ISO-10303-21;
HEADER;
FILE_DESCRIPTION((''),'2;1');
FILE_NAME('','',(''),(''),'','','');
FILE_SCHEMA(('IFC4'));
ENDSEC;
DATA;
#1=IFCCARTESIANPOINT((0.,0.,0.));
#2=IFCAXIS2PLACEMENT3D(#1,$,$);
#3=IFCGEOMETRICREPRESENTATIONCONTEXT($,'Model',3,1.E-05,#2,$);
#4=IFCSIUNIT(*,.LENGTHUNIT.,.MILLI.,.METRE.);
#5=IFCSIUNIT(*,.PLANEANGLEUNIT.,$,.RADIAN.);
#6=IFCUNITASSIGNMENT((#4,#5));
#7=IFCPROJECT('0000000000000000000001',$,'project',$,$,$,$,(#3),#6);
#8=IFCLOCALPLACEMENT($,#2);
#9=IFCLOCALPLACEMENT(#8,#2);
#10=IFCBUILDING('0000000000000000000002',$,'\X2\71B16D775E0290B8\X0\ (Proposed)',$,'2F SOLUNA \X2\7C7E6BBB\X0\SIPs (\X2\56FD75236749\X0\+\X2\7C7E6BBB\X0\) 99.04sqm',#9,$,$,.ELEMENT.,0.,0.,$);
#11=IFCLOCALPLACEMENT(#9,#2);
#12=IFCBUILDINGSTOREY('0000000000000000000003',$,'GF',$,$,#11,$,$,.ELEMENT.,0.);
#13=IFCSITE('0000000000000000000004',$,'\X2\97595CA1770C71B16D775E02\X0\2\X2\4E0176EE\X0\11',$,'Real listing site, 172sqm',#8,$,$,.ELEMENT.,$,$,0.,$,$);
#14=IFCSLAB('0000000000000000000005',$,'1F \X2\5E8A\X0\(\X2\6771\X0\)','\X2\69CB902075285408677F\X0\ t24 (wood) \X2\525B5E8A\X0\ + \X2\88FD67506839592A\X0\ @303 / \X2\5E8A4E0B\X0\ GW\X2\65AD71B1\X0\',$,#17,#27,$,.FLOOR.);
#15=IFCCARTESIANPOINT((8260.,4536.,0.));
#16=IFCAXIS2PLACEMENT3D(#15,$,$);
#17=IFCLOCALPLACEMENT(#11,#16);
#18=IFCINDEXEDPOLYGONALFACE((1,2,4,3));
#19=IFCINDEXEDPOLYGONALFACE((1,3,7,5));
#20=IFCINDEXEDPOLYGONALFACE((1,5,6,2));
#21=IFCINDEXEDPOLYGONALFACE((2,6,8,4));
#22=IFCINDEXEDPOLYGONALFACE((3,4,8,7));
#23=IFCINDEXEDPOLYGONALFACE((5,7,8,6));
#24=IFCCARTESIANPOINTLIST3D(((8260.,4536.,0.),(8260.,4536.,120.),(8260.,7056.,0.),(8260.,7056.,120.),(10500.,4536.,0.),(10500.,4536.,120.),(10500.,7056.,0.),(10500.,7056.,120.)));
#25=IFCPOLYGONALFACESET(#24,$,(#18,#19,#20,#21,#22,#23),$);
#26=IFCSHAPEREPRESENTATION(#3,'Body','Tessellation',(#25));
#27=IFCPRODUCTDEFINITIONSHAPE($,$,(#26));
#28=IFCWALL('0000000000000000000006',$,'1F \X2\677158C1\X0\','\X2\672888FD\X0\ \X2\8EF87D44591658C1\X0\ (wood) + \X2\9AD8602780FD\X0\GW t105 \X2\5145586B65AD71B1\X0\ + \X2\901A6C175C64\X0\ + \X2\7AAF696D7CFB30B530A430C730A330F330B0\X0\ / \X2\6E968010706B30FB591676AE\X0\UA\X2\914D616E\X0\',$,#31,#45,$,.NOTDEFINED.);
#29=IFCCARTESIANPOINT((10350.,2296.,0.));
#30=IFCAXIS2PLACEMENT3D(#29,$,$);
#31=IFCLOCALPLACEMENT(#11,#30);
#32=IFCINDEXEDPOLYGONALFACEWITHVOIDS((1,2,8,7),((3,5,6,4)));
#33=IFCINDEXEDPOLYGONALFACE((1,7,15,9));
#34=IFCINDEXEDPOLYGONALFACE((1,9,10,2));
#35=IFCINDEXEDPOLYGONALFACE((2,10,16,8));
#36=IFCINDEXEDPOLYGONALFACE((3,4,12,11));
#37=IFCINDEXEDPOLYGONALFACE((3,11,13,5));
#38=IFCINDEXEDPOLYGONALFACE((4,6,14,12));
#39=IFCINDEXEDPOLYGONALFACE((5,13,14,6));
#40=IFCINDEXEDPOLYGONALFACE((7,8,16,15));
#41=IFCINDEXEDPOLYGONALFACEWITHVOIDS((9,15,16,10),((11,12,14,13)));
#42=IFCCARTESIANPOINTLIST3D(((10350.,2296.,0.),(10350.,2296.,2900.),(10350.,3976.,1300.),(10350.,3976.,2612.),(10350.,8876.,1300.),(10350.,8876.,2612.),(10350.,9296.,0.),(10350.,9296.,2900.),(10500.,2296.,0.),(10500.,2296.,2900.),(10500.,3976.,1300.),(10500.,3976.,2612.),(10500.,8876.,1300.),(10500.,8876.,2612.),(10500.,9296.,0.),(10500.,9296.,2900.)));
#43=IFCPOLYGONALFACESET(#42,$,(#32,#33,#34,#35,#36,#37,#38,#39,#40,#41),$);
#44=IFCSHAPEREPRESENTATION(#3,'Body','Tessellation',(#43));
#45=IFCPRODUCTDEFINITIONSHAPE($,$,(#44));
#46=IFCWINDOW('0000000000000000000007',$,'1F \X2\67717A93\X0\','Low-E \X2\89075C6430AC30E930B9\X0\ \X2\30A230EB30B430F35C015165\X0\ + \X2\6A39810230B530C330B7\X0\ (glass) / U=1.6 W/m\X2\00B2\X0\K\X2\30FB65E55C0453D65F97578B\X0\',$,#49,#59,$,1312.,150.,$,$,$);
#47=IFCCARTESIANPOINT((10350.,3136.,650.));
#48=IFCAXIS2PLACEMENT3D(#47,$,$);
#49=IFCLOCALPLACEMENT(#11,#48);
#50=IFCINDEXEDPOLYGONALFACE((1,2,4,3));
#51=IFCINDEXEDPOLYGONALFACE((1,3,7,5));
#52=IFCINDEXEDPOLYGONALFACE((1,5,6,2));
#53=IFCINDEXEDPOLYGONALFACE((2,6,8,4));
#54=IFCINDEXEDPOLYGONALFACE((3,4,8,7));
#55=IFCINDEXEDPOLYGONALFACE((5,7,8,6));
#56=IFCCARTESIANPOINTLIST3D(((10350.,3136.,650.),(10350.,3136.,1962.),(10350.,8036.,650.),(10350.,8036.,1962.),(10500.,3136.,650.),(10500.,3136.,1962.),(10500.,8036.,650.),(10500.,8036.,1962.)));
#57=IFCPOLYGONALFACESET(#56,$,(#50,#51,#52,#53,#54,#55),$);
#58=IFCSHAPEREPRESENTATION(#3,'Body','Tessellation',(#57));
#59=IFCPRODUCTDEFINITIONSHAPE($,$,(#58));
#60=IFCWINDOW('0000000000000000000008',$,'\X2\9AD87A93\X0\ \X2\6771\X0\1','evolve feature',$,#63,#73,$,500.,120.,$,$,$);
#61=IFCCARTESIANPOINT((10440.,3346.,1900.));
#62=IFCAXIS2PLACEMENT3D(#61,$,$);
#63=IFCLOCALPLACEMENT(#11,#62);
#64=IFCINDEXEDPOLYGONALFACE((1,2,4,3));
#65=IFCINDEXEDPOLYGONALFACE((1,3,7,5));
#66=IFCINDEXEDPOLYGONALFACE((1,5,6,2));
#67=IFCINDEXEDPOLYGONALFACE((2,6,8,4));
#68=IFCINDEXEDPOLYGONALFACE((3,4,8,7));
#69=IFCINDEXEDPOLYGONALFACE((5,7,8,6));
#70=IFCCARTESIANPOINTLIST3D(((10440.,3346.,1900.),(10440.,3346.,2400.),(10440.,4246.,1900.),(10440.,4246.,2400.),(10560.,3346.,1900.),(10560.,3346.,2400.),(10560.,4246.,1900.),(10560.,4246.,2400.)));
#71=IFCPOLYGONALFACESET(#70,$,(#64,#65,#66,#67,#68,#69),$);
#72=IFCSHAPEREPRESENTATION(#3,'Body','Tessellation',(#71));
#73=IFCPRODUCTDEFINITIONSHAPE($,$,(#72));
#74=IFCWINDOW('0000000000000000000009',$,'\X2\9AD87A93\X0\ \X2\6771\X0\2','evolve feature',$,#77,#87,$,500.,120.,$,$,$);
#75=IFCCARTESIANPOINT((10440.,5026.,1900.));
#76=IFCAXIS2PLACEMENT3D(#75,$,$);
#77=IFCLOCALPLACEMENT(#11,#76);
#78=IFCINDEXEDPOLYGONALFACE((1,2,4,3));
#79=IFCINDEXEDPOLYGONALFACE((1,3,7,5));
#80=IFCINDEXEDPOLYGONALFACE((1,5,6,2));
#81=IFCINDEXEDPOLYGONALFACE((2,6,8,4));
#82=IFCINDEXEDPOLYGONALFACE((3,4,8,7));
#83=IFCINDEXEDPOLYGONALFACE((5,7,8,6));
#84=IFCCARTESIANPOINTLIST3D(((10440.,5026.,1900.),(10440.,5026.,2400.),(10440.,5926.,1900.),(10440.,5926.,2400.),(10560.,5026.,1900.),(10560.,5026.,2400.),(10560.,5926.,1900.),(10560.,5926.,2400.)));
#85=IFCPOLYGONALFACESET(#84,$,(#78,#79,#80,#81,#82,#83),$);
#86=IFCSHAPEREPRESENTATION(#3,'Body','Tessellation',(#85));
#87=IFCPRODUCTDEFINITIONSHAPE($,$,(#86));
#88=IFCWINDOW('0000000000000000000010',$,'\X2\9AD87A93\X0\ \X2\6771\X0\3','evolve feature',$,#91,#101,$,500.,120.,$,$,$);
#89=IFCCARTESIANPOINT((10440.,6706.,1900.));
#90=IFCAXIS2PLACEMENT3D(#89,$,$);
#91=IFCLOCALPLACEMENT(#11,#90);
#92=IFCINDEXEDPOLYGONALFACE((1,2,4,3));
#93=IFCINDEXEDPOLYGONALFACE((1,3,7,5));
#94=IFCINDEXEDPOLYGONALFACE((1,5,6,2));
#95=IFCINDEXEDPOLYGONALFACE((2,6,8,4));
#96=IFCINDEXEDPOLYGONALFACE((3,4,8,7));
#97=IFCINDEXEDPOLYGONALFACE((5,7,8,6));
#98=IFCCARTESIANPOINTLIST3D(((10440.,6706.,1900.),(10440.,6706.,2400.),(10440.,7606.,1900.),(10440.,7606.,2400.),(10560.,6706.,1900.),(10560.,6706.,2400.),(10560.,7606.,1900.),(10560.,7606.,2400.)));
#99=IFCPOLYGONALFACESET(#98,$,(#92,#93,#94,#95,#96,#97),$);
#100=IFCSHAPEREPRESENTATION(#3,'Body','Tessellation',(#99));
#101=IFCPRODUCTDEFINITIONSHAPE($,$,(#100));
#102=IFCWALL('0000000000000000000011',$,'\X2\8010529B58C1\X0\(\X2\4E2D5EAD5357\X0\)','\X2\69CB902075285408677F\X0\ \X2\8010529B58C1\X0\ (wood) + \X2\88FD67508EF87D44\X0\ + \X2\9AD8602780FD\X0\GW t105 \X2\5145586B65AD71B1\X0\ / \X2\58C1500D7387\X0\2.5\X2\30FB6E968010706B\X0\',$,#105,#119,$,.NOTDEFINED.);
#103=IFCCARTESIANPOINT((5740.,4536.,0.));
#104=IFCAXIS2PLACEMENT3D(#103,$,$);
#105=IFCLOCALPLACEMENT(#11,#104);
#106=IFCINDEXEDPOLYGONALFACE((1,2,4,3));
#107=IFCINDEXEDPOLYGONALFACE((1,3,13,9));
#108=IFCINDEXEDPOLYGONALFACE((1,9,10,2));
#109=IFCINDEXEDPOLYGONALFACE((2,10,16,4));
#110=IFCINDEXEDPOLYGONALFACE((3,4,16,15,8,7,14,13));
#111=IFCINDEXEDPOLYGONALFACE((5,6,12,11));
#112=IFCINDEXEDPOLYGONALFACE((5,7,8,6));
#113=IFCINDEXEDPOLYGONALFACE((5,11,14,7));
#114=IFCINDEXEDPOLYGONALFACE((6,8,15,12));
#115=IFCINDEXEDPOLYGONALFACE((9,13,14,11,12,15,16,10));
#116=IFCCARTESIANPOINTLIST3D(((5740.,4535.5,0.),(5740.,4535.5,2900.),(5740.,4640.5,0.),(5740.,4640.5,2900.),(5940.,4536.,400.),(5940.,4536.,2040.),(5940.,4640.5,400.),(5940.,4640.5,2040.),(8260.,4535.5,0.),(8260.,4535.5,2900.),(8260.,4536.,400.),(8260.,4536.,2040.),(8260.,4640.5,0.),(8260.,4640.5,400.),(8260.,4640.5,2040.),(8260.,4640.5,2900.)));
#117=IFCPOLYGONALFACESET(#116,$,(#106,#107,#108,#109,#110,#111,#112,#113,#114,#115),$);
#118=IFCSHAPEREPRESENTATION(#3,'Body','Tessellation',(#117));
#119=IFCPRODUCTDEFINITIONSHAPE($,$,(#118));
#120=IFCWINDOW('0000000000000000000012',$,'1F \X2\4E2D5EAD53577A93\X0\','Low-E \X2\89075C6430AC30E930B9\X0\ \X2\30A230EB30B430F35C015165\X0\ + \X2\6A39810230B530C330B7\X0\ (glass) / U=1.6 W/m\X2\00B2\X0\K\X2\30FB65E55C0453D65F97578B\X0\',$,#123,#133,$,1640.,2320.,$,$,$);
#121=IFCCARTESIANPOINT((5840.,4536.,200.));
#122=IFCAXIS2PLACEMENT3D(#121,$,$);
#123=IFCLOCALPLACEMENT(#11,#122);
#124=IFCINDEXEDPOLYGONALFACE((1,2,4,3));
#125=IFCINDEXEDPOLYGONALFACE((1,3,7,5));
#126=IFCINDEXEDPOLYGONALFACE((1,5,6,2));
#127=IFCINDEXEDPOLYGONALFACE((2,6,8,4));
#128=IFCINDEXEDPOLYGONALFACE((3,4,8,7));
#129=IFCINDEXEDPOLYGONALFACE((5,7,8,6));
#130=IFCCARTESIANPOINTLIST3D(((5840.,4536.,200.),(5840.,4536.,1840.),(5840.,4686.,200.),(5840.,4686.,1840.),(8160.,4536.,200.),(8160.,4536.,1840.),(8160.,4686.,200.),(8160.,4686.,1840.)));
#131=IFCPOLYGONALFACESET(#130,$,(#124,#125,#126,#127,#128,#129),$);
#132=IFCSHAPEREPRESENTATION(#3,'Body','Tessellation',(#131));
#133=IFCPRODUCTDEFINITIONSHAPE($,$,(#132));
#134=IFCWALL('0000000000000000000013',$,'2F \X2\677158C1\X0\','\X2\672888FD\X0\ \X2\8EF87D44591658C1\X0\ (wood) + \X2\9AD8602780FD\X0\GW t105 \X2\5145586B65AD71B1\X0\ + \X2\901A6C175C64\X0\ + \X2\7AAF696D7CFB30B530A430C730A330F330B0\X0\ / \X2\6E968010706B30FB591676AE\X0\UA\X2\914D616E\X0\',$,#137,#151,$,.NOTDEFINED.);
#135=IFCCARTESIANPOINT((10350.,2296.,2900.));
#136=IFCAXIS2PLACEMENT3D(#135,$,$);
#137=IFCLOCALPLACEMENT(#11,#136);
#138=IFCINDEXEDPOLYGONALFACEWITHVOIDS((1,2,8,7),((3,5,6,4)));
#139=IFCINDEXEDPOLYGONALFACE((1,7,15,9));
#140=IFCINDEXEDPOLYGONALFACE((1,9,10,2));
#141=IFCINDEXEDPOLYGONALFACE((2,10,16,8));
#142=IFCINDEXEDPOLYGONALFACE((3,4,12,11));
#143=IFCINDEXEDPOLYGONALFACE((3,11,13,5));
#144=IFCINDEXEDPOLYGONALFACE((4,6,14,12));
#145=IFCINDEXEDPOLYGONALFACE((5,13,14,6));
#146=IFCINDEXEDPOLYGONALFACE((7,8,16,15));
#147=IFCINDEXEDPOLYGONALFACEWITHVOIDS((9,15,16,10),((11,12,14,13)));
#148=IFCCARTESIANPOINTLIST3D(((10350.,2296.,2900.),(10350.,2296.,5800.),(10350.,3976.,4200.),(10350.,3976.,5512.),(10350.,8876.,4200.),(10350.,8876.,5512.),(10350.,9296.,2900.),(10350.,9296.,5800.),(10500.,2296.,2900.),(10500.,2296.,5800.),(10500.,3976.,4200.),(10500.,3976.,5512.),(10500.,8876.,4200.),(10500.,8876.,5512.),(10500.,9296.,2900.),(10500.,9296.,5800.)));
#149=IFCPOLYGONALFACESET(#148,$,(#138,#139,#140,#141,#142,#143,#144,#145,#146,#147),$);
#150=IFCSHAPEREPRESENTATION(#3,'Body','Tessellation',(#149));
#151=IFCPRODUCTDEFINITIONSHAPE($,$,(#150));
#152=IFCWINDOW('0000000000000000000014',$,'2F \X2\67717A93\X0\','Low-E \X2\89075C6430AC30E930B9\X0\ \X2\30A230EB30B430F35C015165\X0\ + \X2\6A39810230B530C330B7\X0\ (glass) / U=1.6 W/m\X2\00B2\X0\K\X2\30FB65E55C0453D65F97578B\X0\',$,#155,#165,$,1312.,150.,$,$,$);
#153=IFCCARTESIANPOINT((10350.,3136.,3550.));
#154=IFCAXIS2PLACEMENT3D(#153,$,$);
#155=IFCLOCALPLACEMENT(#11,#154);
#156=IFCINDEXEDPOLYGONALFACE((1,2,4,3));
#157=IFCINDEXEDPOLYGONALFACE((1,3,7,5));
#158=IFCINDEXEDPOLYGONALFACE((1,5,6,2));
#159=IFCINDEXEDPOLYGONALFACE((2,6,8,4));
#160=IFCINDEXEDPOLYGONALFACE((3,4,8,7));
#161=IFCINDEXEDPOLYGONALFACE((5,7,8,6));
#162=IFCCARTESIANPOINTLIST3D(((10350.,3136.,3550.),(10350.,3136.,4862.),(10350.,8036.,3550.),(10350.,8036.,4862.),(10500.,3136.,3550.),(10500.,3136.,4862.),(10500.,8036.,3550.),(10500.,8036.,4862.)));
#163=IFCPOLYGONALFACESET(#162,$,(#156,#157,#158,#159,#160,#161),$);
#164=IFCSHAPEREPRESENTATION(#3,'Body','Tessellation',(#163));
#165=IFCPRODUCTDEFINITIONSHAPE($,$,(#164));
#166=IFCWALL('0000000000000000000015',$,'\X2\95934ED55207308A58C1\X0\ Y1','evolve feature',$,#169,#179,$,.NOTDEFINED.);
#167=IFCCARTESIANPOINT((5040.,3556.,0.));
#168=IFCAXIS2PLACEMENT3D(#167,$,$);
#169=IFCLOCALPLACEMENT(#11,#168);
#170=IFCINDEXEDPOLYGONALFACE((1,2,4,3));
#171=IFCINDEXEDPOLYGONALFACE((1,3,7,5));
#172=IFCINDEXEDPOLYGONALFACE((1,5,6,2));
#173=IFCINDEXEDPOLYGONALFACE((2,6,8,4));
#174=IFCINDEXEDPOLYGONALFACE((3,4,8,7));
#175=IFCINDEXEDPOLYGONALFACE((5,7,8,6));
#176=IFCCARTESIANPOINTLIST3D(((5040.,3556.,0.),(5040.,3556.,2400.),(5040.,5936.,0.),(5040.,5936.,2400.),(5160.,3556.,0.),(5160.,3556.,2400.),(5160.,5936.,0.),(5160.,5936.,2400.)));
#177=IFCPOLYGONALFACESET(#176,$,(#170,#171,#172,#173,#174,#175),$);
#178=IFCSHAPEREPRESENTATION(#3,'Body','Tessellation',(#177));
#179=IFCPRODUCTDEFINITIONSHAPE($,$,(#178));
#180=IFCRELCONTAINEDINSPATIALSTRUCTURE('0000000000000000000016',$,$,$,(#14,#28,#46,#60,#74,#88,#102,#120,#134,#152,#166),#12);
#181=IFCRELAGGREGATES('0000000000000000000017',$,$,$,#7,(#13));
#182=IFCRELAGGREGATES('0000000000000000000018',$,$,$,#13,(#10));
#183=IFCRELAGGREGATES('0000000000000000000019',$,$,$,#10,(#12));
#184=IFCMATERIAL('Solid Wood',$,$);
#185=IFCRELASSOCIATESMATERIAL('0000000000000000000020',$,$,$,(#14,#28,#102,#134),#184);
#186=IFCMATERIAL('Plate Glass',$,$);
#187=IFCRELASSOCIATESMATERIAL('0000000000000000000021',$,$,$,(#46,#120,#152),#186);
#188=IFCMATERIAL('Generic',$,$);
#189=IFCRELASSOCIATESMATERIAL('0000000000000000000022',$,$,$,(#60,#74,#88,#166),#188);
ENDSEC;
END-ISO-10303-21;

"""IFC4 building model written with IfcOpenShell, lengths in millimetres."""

from ifc_helpers import new_model, si_unit, frame, frame_2d, origin, place, context, project, spatial, rectangle, extrude, material, element, fill, save


model = new_model("IFC4")

# Units and contexts
model_context = context("Model", 3, precision=1e-05, world=origin())
ifc_project = project(units=[si_unit("LENGTHUNIT", "METRE", prefix="MILLI"), si_unit("PLANEANGLEUNIT", "RADIAN")], contexts=[model_context])

# Site, building, storey
site_placement = place(None, origin())
site = spatial("IfcSite", under=ifc_project, at=site_placement, Name="静岡県熱海市2丁目11", ObjectType="Real listing site, 172sqm", CompositionType="ELEMENT", RefElevation=0.0)
building_placement = place(site_placement, origin())
building = spatial("IfcBuilding", under=site, at=building_placement, Name="熱海市邸 (Proposed)", ObjectType="2F SOLUNA 籾殻SIPs (国産杉+籾殻) 99.04sqm", CompositionType="ELEMENT", ElevationOfRefHeight=0.0, ElevationOfTerrain=0.0)
storey_placement = place(building_placement, origin())
storey = spatial("IfcBuildingStorey", under=building, at=storey_placement, Name="GF", CompositionType="ELEMENT", Elevation=0.0)

# Slab
ifc_material_1 = material(Name="Solid Wood")
slab_placement = place(storey_placement, frame((8260.0, 4536.0, 0.0)))
element("IfcSlab", 1, at=slab_placement, inside=storey, material=ifc_material_1, Name="1F 床(東)", Description="構造用合板 t24 (wood) 剛床 + 製材根太 @303 / 床下 GW断熱", PredefinedType="FLOOR", context=model_context, shape_type="SweptSolid", body=[
    extrude(rectangle(XDim=2240.0, YDim=2520.0, at=frame_2d((1120.0, 1260.0))), frame((8260.0, 4536.0, 0.0)), (0.0, 0.0, 1.0), 120.0),
])

# Wall, openings, windows
wall_1_placement = place(storey_placement, frame((10350.0, 2296.0, 0.0)))
wall_1 = element("IfcWall", 2, at=wall_1_placement, inside=storey, material=ifc_material_1, Name="1F 東壁", Description="木製 軸組外壁 (wood) + 高性能GW t105 充填断熱 + 通気層 + 窯業系サイディング / 準耐火・外皮UA配慮", PredefinedType="NOTDEFINED", context=model_context, shape_type="SweptSolid", body=[
    extrude(rectangle(XDim=150.0, YDim=7000.0, at=frame_2d((75.0, 3500.0))), frame((10350.0, 2296.0, 0.0)), (0.0, 0.0, 1.0), 2900.0),
])
opening_1_placement = place(storey_placement, frame((10350.0, 3136.0, 650.0)))
opening_1 = element("IfcOpeningElement", 3, at=opening_1_placement, cuts=wall_1, PredefinedType="NOTDEFINED", context=model_context, shape_type="SweptSolid", body=[
    extrude(rectangle(XDim=150.0, YDim=4900.0, at=frame_2d((75.0, 2450.0))), frame((10350.0, 3136.0, 650.0)), (0.0, 0.0, 1.0), 1312.0),
])
opening_2_placement = place(storey_placement, frame((10440.0, 3346.0, 1900.0)))
opening_2 = element("IfcOpeningElement", 4, at=opening_2_placement, cuts=wall_1, PredefinedType="NOTDEFINED", context=model_context, shape_type="SweptSolid", body=[
    extrude(rectangle(XDim=120.0, YDim=900.0, at=frame_2d((60.0, 450.0))), frame((10440.0, 3346.0, 1900.0)), (0.0, 0.0, 1.0), 500.0),
])
opening_3_placement = place(storey_placement, frame((10440.0, 5026.0, 1900.0)))
opening_3 = element("IfcOpeningElement", 5, at=opening_3_placement, cuts=wall_1, PredefinedType="NOTDEFINED", context=model_context, shape_type="SweptSolid", body=[
    extrude(rectangle(XDim=120.0, YDim=900.0, at=frame_2d((60.0, 450.0))), frame((10440.0, 5026.0, 1900.0)), (0.0, 0.0, 1.0), 500.0),
])
opening_4_placement = place(storey_placement, frame((10440.0, 6706.0, 1900.0)))
opening_4 = element("IfcOpeningElement", 6, at=opening_4_placement, cuts=wall_1, PredefinedType="NOTDEFINED", context=model_context, shape_type="SweptSolid", body=[
    extrude(rectangle(XDim=120.0, YDim=900.0, at=frame_2d((60.0, 450.0))), frame((10440.0, 6706.0, 1900.0)), (0.0, 0.0, 1.0), 500.0),
])
ifc_material_2 = material(Name="Plate Glass")
window_1_placement = place(storey_placement, frame((10350.0, 3136.0, 650.0)))
window_1 = element("IfcWindow", 7, at=window_1_placement, inside=storey, material=ifc_material_2, Name="1F 東窓", Description="Low-E 複層ガラス アルゴン封入 + 樹脂サッシ (glass) / U=1.6 W/m²K・日射取得型", OverallHeight=1312.0, OverallWidth=150.0, context=model_context, shape_type="SweptSolid", body=[
    extrude(rectangle(XDim=150.0, YDim=4900.0, at=frame_2d((75.0, 2450.0))), frame((10350.0, 3136.0, 650.0)), (0.0, 0.0, 1.0), 1312.0),
])
fill(opening_1, window_1)
ifc_material_3 = material(Name="Generic")
window_2_placement = place(storey_placement, frame((10440.0, 3346.0, 1900.0)))
window_2 = element("IfcWindow", 8, at=window_2_placement, inside=storey, material=ifc_material_3, Name="高窓 東1", Description="evolve feature", OverallHeight=500.0, OverallWidth=120.0, context=model_context, shape_type="SweptSolid", body=[
    extrude(rectangle(XDim=120.0, YDim=900.0, at=frame_2d((60.0, 450.0))), frame((10440.0, 3346.0, 1900.0)), (0.0, 0.0, 1.0), 500.0),
])
fill(opening_2, window_2)
window_3_placement = place(storey_placement, frame((10440.0, 5026.0, 1900.0)))
window_3 = element("IfcWindow", 9, at=window_3_placement, inside=storey, material=ifc_material_3, Name="高窓 東2", Description="evolve feature", OverallHeight=500.0, OverallWidth=120.0, context=model_context, shape_type="SweptSolid", body=[
    extrude(rectangle(XDim=120.0, YDim=900.0, at=frame_2d((60.0, 450.0))), frame((10440.0, 5026.0, 1900.0)), (0.0, 0.0, 1.0), 500.0),
])
fill(opening_3, window_3)
window_4_placement = place(storey_placement, frame((10440.0, 6706.0, 1900.0)))
window_4 = element("IfcWindow", 10, at=window_4_placement, inside=storey, material=ifc_material_3, Name="高窓 東3", Description="evolve feature", OverallHeight=500.0, OverallWidth=120.0, context=model_context, shape_type="SweptSolid", body=[
    extrude(rectangle(XDim=120.0, YDim=900.0, at=frame_2d((60.0, 450.0))), frame((10440.0, 6706.0, 1900.0)), (0.0, 0.0, 1.0), 500.0),
])
fill(opening_4, window_4)

# Wall, opening, window
wall_2_placement = place(storey_placement, frame((5740.0, 4536.0, 0.0)))
wall_2 = element("IfcWall", 11, at=wall_2_placement, inside=storey, material=ifc_material_1, Name="耐力壁(中庭南)", Description="構造用合板 耐力壁 (wood) + 製材軸組 + 高性能GW t105 充填断熱 / 壁倍率2.5・準耐火", PredefinedType="NOTDEFINED", context=model_context, shape_type="SweptSolid", body=[
    extrude(rectangle(XDim=2520.0, YDim=105.0, at=frame_2d((1260.0, 52.0))), frame((5740.0, 4536.0, 0.0)), (0.0, 0.0, 1.0), 2900.0),
])
opening_5_placement = place(storey_placement, frame((5840.0, 4536.0, 200.0)))
opening_5 = element("IfcOpeningElement", 12, at=opening_5_placement, cuts=wall_2, PredefinedType="NOTDEFINED", context=model_context, shape_type="SweptSolid", body=[
    extrude(rectangle(XDim=2320.0, YDim=150.0, at=frame_2d((1160.0, 75.0))), frame((5840.0, 4536.0, 200.0)), (0.0, 0.0, 1.0), 1640.0),
])
window_5_placement = place(storey_placement, frame((5840.0, 4536.0, 200.0)))
window_5 = element("IfcWindow", 13, at=window_5_placement, inside=storey, material=ifc_material_2, Name="1F 中庭南窓", Description="Low-E 複層ガラス アルゴン封入 + 樹脂サッシ (glass) / U=1.6 W/m²K・日射取得型", OverallHeight=1640.0, OverallWidth=2320.0, context=model_context, shape_type="SweptSolid", body=[
    extrude(rectangle(XDim=2320.0, YDim=150.0, at=frame_2d((1160.0, 75.0))), frame((5840.0, 4536.0, 200.0)), (0.0, 0.0, 1.0), 1640.0),
])
fill(opening_5, window_5)

# Wall, opening, window
wall_3_placement = place(storey_placement, frame((10350.0, 2296.0, 2900.0)))
wall_3 = element("IfcWall", 14, at=wall_3_placement, inside=storey, material=ifc_material_1, Name="2F 東壁", Description="木製 軸組外壁 (wood) + 高性能GW t105 充填断熱 + 通気層 + 窯業系サイディング / 準耐火・外皮UA配慮", PredefinedType="NOTDEFINED", context=model_context, shape_type="SweptSolid", body=[
    extrude(rectangle(XDim=150.0, YDim=7000.0, at=frame_2d((75.0, 3500.0))), frame((10350.0, 2296.0, 2900.0)), (0.0, 0.0, 1.0), 2900.0),
])
opening_6_placement = place(storey_placement, frame((10350.0, 3136.0, 3550.0)))
opening_6 = element("IfcOpeningElement", 15, at=opening_6_placement, cuts=wall_3, PredefinedType="NOTDEFINED", context=model_context, shape_type="SweptSolid", body=[
    extrude(rectangle(XDim=150.0, YDim=4900.0, at=frame_2d((75.0, 2450.0))), frame((10350.0, 3136.0, 3550.0)), (0.0, 0.0, 1.0), 1312.0),
])
window_6_placement = place(storey_placement, frame((10350.0, 3136.0, 3550.0)))
window_6 = element("IfcWindow", 16, at=window_6_placement, inside=storey, material=ifc_material_2, Name="2F 東窓", Description="Low-E 複層ガラス アルゴン封入 + 樹脂サッシ (glass) / U=1.6 W/m²K・日射取得型", OverallHeight=1312.0, OverallWidth=150.0, context=model_context, shape_type="SweptSolid", body=[
    extrude(rectangle(XDim=150.0, YDim=4900.0, at=frame_2d((75.0, 2450.0))), frame((10350.0, 3136.0, 3550.0)), (0.0, 0.0, 1.0), 1312.0),
])
fill(opening_6, window_6)

# Wall
wall_4_placement = place(storey_placement, frame((5040.0, 3556.0, 0.0)))
element("IfcWall", 17, at=wall_4_placement, inside=storey, material=ifc_material_3, Name="間仕切り壁 Y1", Description="evolve feature", PredefinedType="NOTDEFINED", context=model_context, shape_type="SweptSolid", body=[
    extrude(rectangle(XDim=120.0, YDim=2380.0, at=frame_2d((60.0, 1190.0))), frame((5040.0, 3556.0, 0.0)), (0.0, 0.0, 1.0), 2400.0),
])

save(model, "model.ifc")
